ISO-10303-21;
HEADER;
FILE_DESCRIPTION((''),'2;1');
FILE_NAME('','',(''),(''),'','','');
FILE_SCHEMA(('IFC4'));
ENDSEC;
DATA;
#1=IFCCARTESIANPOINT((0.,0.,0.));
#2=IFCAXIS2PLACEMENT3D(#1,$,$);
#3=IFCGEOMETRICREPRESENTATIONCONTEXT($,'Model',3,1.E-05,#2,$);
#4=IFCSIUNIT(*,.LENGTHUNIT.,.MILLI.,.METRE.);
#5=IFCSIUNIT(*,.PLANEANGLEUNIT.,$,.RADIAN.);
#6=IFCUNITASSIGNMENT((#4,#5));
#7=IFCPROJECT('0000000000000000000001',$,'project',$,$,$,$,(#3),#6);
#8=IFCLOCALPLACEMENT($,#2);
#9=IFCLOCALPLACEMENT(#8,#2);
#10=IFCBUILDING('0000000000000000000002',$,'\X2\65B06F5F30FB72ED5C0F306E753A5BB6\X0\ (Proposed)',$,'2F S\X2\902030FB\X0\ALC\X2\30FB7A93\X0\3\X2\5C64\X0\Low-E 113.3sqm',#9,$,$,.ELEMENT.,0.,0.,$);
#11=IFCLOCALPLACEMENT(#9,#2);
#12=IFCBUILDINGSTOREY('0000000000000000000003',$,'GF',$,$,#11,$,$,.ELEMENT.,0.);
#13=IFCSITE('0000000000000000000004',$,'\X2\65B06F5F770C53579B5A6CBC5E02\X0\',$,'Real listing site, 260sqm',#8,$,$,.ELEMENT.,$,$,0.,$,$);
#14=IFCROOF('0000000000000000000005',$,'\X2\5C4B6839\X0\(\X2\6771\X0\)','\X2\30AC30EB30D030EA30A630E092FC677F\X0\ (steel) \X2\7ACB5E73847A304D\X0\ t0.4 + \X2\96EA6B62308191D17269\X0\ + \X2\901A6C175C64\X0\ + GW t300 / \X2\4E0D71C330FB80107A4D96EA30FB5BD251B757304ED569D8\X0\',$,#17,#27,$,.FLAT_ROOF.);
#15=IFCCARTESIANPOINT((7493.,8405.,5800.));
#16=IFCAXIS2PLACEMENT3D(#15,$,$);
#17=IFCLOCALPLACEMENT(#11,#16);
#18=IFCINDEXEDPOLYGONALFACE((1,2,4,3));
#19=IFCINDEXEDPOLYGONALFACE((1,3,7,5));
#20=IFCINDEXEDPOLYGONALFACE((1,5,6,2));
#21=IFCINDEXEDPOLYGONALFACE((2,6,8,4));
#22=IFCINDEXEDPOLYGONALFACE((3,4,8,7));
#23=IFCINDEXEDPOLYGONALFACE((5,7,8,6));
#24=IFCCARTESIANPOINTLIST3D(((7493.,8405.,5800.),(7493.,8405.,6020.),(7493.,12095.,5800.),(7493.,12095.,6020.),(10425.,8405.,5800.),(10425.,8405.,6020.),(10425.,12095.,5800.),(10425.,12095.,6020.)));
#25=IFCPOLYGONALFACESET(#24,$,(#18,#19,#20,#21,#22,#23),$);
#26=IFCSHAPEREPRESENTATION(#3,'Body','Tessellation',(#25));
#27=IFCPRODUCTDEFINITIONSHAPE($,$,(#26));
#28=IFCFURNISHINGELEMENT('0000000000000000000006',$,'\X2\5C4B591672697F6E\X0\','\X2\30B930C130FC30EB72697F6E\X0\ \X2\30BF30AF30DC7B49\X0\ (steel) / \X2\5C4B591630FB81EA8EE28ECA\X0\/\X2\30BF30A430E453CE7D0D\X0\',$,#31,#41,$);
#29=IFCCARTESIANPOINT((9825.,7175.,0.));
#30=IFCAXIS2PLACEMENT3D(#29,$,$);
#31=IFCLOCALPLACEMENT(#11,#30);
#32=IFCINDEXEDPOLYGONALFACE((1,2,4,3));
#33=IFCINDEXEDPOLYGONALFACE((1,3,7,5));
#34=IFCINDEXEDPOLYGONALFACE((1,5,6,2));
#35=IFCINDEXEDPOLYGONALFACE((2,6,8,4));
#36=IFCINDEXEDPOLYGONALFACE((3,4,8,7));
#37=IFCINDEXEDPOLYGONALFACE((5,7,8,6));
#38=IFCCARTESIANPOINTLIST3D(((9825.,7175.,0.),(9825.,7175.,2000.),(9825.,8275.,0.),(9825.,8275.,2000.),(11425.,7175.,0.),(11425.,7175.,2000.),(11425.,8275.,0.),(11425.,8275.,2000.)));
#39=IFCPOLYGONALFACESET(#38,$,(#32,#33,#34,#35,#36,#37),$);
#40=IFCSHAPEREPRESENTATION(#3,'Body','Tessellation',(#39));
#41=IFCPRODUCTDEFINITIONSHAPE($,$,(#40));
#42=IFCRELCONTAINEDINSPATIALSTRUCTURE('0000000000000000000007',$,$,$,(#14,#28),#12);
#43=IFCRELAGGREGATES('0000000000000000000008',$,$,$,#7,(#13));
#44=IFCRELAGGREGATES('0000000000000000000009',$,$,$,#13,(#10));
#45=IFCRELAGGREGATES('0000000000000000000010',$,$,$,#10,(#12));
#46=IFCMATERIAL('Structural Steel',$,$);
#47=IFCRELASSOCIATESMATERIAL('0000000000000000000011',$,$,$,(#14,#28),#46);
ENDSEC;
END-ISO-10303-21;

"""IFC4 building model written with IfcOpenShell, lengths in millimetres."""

from ifc_helpers import new_model, si_unit, frame, frame_2d, origin, place, context, project, spatial, rectangle, extrude, material, element, save


model = new_model("IFC4")

# Units and contexts
model_context = context("Model", 3, precision=1e-05, world=origin())
ifc_project = project(units=[si_unit("LENGTHUNIT", "METRE", prefix="MILLI"), si_unit("PLANEANGLEUNIT", "RADIAN")], contexts=[model_context])

# Site, building, storey
site_placement = place(None, origin())
site = spatial("IfcSite", under=ifc_project, at=site_placement, Name="新潟県南魚沼市", ObjectType="Real listing site, 260sqm", CompositionType="ELEMENT", RefElevation=0.0)
building_placement = place(site_placement, origin())
building = spatial("IfcBuilding", under=site, at=building_placement, Name="新潟・狭小の町家 (Proposed)", ObjectType="2F S造・ALC・窓3層Low-E 113.3sqm", CompositionType="ELEMENT", ElevationOfRefHeight=0.0, ElevationOfTerrain=0.0)
storey_placement = place(building_placement, origin())
storey = spatial("IfcBuildingStorey", under=building, at=storey_placement, Name="GF", CompositionType="ELEMENT", Elevation=0.0)

# Roof
ifc_material_1 = material(Name="Structural Steel")
for number, where, name in (
    (1, (7493.0, 8405.0, 5800.0), "屋根(東)"),
):
    element("IfcRoof", number, at=place(storey_placement, frame(where)), inside=storey, material=ifc_material_1, Name=name, Description="ガルバリウム鋼板 (steel) 立平葺き t0.4 + 雪止め金物 + 通気層 + GW t300 / 不燃・耐積雪・寒冷地仕様", PredefinedType="FLAT_ROOF", context=model_context, shape_type="SweptSolid", body=[
        extrude(rectangle(XDim=2932.0, YDim=3690.0, at=frame_2d((1466.0, 1845.0))), frame((7493.0, 8405.0, 5800.0)), (0.0, 0.0, 1.0), 220.0),
    ])

# Furnishing element
furnishing_placement = place(storey_placement, frame((9825.0, 7175.0, 0.0)))
element("IfcFurnishingElement", 2, at=furnishing_placement, inside=storey, material=ifc_material_1, Name="屋外物置", Description="スチール物置 タクボ等 (steel) / 屋外・自転車/タイヤ収納", context=model_context, shape_type="SweptSolid", body=[
    extrude(rectangle(XDim=1600.0, YDim=1100.0, at=frame_2d((800.0, 550.0))), frame((9825.0, 7175.0, 0.0)), (0.0, 0.0, 1.0), 2000.0),
])

save(model, "model.ifc")
